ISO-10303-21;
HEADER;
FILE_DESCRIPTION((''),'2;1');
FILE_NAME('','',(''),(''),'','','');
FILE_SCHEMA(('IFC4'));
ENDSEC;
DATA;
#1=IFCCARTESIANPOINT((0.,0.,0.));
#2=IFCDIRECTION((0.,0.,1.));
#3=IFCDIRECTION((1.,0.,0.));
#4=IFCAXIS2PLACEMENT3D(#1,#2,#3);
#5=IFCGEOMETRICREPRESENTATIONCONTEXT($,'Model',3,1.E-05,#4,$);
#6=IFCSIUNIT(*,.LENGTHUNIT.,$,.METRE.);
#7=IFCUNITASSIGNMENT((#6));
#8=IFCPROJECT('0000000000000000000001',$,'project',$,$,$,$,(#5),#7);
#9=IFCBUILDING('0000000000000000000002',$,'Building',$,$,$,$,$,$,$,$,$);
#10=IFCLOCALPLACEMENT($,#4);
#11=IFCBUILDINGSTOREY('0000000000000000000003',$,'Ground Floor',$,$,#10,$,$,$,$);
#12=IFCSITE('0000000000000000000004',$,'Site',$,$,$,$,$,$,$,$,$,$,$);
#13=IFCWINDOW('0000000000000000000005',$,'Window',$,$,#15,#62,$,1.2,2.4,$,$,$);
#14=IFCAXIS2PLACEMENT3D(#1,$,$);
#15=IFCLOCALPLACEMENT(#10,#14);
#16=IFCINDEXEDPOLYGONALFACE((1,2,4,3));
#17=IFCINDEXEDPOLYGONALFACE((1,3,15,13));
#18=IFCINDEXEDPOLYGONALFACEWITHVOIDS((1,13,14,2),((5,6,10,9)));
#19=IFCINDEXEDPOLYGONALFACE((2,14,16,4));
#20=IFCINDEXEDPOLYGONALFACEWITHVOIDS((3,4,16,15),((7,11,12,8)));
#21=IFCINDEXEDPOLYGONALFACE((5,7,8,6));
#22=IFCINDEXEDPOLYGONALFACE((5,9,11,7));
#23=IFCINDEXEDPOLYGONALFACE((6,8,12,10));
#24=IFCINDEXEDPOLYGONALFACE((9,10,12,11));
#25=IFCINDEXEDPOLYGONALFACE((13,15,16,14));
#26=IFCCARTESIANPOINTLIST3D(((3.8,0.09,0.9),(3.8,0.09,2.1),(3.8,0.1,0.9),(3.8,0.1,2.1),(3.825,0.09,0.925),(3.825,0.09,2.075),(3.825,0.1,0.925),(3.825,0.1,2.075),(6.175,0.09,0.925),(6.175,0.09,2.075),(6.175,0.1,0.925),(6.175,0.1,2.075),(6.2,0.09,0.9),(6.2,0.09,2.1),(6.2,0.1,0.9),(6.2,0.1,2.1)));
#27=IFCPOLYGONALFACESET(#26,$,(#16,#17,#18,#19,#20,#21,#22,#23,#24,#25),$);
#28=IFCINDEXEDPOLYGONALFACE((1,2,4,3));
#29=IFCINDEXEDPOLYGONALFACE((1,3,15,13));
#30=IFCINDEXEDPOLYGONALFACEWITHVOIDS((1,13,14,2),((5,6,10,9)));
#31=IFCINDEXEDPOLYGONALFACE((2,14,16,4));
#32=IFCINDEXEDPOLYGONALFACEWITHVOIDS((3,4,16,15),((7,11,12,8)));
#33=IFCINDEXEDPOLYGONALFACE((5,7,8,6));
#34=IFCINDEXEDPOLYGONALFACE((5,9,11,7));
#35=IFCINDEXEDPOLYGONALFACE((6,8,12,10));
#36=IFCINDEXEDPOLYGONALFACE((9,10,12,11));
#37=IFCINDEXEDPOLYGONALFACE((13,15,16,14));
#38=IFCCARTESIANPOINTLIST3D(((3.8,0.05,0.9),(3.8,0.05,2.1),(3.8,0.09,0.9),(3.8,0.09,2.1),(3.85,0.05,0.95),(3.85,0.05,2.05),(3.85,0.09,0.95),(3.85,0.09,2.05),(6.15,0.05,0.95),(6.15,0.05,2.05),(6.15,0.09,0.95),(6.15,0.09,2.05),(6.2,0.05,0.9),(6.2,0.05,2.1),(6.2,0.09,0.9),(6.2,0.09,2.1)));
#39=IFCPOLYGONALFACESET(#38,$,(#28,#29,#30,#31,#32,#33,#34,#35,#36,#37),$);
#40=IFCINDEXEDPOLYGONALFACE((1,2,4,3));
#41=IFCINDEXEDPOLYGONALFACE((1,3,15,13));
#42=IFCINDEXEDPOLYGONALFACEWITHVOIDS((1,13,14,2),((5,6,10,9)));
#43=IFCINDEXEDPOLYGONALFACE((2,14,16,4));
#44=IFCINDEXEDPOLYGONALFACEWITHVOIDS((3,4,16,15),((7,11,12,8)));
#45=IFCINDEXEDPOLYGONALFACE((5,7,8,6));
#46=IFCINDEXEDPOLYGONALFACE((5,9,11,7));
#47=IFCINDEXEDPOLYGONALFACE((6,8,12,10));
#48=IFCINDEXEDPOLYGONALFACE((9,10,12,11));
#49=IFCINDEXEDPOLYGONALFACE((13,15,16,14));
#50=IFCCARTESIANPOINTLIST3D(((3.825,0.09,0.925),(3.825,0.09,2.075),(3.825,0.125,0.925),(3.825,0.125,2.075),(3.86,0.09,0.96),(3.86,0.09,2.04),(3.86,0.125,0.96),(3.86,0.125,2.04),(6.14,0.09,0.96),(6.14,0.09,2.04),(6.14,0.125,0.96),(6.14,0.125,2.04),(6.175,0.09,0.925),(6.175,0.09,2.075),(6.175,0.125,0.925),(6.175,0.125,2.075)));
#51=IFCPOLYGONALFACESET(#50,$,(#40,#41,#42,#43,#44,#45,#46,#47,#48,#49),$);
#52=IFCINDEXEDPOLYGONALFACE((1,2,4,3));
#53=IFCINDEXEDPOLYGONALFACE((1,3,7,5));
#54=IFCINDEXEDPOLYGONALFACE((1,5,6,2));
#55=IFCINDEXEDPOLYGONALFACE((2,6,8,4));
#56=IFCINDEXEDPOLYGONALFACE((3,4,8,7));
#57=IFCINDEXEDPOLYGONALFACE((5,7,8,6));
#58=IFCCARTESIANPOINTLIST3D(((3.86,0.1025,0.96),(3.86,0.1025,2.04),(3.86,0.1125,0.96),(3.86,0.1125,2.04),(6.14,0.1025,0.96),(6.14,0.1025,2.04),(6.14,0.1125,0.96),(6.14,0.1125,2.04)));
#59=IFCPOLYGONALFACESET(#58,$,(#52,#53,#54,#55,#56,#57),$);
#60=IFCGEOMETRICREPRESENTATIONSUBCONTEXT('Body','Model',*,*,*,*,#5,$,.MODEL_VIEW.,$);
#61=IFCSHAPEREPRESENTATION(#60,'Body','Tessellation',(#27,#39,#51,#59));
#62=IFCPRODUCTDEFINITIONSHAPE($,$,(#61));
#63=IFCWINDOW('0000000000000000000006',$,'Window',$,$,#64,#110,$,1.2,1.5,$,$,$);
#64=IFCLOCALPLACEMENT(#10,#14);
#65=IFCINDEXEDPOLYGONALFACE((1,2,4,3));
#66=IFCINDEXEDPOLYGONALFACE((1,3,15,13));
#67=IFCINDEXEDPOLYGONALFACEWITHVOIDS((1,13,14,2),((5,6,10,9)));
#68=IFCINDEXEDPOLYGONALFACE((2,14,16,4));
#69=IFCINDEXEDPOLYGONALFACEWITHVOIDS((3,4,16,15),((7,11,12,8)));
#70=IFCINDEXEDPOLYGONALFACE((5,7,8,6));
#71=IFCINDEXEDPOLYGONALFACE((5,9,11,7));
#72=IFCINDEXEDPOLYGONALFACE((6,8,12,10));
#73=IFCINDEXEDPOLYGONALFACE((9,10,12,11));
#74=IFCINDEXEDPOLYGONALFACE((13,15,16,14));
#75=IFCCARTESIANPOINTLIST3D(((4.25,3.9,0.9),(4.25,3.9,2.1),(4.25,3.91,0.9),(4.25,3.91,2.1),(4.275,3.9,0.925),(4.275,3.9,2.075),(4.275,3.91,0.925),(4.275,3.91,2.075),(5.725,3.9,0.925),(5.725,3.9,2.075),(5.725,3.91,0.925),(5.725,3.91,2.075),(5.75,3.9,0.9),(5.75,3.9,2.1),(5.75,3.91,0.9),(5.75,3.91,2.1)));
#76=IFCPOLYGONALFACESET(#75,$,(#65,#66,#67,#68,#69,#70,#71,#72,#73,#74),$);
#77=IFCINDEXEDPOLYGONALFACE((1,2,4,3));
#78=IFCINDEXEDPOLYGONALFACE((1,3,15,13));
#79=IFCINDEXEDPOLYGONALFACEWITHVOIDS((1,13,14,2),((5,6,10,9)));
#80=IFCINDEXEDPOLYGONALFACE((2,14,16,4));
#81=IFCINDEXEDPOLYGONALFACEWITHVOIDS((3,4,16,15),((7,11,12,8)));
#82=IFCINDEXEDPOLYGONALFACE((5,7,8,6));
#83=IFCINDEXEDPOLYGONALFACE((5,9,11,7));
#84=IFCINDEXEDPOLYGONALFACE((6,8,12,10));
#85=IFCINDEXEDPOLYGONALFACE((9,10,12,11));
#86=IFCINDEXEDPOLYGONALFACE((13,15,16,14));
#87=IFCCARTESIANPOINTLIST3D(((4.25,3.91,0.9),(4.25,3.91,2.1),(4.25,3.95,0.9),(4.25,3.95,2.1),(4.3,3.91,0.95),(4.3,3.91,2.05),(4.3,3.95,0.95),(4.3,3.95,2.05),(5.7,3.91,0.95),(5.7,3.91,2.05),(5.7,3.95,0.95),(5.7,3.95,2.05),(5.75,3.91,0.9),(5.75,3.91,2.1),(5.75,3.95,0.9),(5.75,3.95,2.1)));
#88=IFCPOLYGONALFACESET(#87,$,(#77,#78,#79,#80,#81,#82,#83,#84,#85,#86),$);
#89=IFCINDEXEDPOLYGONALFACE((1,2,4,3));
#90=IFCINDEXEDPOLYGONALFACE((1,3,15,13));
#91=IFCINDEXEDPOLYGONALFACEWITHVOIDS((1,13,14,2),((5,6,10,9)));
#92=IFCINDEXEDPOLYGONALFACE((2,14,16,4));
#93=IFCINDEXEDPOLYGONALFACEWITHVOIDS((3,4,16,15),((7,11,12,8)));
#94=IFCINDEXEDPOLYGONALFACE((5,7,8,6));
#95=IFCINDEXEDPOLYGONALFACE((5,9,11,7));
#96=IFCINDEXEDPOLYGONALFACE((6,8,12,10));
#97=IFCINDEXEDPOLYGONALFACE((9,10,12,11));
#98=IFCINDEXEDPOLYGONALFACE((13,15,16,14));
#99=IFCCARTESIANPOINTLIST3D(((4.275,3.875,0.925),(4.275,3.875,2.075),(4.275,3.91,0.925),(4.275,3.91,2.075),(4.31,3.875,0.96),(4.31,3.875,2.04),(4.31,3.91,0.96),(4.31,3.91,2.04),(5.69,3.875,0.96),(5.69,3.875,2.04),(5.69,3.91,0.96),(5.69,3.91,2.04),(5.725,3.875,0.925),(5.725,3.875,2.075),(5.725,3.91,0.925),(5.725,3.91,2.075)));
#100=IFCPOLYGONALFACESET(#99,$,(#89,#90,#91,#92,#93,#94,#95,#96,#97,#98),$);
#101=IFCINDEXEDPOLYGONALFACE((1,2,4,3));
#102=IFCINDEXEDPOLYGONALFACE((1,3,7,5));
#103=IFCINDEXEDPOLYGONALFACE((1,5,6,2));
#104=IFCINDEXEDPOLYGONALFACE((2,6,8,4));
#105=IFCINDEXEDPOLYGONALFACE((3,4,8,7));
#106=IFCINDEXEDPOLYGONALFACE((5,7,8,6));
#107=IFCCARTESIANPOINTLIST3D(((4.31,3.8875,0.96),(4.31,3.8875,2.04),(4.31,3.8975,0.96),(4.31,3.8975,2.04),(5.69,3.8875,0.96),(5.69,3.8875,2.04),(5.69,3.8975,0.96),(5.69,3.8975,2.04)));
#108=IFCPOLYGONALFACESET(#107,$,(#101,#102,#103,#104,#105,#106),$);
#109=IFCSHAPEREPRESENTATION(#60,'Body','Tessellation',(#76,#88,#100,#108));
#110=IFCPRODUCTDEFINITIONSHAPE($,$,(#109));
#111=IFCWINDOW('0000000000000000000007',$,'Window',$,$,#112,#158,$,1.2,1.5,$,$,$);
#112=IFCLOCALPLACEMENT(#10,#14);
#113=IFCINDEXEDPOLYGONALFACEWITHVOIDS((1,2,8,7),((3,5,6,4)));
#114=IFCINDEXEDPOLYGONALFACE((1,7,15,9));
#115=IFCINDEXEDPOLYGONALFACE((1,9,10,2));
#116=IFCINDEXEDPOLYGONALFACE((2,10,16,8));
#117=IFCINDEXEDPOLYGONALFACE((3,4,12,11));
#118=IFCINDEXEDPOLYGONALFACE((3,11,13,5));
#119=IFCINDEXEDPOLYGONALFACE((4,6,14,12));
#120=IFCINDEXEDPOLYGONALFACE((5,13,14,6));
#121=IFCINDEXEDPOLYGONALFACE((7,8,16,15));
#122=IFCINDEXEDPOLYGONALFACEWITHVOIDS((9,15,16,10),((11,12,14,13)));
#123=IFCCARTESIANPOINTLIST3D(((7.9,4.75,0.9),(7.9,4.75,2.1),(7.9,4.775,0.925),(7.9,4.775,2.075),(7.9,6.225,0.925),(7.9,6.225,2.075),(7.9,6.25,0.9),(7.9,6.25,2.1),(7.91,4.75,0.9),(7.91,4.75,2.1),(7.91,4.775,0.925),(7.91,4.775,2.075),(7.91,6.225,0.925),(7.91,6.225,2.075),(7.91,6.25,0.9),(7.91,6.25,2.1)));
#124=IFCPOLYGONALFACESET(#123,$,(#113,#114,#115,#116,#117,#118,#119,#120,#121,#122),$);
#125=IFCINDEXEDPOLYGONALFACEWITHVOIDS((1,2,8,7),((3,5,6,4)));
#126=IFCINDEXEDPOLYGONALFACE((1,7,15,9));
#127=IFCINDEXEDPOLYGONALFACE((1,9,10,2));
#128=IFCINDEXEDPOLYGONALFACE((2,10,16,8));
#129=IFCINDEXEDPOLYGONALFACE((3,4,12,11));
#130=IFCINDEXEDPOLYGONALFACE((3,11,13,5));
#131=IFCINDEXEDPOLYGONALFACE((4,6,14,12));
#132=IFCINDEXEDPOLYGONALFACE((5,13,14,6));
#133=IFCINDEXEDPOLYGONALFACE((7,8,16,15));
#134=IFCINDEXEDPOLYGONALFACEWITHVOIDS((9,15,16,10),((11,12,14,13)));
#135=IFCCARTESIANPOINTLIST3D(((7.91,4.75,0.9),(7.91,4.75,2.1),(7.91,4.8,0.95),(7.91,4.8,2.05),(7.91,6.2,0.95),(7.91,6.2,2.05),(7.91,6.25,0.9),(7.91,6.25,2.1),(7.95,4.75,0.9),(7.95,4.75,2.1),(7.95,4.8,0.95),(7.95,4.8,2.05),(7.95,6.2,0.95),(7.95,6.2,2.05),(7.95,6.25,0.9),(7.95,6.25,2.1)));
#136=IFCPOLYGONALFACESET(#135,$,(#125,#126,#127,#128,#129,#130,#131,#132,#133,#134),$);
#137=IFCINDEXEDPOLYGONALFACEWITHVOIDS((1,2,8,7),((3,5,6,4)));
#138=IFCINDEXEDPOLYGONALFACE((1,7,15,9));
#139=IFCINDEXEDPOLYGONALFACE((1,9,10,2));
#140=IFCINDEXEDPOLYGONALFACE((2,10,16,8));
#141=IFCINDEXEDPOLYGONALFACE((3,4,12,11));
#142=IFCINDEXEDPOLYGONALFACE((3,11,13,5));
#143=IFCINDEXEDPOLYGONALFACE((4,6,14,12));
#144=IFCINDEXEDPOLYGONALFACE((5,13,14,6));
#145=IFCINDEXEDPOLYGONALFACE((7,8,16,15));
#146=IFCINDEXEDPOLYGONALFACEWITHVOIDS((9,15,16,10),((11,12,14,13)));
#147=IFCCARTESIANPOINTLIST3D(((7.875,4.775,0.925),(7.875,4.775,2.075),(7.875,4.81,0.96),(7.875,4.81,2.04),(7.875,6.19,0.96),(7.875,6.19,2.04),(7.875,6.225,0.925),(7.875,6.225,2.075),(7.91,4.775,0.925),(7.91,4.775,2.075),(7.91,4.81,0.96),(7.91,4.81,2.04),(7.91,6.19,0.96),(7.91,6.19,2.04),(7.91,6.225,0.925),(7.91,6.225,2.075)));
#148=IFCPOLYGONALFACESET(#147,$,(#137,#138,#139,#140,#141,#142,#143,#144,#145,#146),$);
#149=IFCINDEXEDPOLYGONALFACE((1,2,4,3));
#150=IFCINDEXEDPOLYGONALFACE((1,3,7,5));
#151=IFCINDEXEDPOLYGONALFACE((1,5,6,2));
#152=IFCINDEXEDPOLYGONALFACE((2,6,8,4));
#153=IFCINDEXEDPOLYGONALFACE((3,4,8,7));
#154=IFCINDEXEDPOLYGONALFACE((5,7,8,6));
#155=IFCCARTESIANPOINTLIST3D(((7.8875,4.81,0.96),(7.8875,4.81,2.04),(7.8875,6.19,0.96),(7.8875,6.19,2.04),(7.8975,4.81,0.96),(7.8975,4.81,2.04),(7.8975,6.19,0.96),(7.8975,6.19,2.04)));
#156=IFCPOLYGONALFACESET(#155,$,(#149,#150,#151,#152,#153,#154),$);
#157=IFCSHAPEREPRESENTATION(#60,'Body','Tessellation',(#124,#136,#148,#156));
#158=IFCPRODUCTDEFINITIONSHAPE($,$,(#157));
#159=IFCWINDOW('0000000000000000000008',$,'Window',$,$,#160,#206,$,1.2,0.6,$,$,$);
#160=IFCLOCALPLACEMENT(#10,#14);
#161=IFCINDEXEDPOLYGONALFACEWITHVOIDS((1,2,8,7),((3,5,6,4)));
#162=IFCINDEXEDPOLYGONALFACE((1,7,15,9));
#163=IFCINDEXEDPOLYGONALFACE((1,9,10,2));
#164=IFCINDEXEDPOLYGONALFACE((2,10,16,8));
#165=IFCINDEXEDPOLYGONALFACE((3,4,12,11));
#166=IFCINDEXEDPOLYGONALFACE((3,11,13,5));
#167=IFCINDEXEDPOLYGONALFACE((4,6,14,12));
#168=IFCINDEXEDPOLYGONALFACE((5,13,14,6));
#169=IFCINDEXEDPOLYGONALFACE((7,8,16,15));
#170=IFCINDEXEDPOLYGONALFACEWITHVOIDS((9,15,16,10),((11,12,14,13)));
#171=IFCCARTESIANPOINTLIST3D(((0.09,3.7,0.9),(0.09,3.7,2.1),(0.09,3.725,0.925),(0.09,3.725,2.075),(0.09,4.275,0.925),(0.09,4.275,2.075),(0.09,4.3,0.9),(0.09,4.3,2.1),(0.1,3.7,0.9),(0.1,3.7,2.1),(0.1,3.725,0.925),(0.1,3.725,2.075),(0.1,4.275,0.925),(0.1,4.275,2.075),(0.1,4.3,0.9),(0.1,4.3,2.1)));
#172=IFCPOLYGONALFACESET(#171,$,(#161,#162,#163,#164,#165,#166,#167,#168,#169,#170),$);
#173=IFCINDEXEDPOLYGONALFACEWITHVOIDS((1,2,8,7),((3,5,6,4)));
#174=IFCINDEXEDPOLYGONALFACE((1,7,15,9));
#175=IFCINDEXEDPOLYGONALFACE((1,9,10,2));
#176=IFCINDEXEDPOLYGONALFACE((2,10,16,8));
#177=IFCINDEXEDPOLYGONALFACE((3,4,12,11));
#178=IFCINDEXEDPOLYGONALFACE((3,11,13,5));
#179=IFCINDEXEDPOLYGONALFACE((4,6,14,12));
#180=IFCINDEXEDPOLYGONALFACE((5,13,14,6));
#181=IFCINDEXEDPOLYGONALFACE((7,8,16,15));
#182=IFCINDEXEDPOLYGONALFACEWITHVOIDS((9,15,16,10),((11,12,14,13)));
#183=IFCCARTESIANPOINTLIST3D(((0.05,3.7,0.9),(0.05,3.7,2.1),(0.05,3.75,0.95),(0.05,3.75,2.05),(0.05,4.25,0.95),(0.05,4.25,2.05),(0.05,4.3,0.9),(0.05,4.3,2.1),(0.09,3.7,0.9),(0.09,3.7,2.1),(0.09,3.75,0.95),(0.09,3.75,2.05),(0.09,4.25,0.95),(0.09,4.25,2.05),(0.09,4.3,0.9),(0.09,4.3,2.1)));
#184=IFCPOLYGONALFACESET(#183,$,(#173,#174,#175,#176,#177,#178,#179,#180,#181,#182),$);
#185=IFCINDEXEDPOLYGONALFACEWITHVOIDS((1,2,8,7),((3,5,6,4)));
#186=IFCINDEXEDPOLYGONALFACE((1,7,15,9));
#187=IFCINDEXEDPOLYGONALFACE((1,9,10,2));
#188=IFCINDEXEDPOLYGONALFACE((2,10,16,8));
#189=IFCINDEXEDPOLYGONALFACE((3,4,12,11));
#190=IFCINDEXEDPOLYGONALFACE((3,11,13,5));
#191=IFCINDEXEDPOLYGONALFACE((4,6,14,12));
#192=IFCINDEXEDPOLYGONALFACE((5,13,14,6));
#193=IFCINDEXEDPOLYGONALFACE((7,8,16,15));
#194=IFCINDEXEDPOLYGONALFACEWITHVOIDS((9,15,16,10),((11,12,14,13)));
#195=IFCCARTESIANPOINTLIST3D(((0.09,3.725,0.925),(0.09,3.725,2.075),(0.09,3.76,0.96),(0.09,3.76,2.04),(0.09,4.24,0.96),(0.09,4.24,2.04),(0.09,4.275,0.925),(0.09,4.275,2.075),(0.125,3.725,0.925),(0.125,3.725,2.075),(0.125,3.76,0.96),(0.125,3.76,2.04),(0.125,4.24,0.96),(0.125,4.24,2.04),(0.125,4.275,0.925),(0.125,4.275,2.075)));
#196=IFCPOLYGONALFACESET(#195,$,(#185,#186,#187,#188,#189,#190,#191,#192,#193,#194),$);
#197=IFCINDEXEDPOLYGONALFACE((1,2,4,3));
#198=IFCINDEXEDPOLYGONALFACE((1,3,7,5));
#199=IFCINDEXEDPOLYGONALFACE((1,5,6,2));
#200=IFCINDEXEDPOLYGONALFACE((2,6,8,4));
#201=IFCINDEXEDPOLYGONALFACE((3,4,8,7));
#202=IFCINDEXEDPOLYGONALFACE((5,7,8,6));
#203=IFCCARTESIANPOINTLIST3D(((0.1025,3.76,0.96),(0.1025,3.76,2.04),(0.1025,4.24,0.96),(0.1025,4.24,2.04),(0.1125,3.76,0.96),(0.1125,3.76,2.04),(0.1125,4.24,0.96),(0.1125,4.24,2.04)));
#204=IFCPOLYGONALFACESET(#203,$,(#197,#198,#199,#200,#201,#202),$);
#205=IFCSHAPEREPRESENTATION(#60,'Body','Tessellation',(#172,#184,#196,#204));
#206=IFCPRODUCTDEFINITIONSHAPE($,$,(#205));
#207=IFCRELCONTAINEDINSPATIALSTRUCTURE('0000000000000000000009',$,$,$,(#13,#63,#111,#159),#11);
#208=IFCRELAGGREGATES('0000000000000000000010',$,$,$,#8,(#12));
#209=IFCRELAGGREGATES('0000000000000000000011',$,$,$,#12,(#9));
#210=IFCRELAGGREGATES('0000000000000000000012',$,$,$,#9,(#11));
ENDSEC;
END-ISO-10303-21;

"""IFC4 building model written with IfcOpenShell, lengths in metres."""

from ifc_helpers import new_model, si_unit, frame, origin_with_axes, place, context, subcontext, project, spatial, line, indexed_curve, outline, extrude, element, save


model = new_model("IFC4")

# Units and contexts
model_context = context("Model", 3, precision=1e-05, world=origin_with_axes())
body_context = subcontext(model_context, "Body", "Model", "MODEL_VIEW")
ifc_project = project(units=[si_unit("LENGTHUNIT", "METRE")], contexts=[model_context])

# Site, building, storey
site = spatial("IfcSite", under=ifc_project, Name="Site")
building = spatial("IfcBuilding", under=site, Name="Building")
storey_placement = place(None, origin_with_axes())
storey = spatial("IfcBuildingStorey", under=building, at=storey_placement, Name="Ground Floor")

# Windows
window_1_placement = place(storey_placement, frame((3.8, 0.0, 0.9), z_axis=(0.0, 0.0, 1.0), x_axis=(1.0, 0.0, 0.0)))
element("IfcWindow", 1, at=window_1_placement, inside=storey, Name="Window", OverallHeight=1.2, OverallWidth=2.4, context=body_context, shape_type="SweptSolid", body=[
    extrude(outline(indexed_curve([(0.0, 0.0), (2.4, 0.0), (2.4, 1.2), (0.0, 1.2)], segments=[line(1, 2, 3, 4, 1)]), holes=[indexed_curve([(0.025, 0.025), (2.375, 0.025), (2.375, 1.175), (0.025, 1.175)], segments=[line(1, 2, 3, 4, 1)])]), frame((0.0, 0.09, 0.0), z_axis=(0.0, -1.0, 0.0), x_axis=(1.0, 0.0, 0.0)), (0.0, 0.0, -1.0), 0.01),
    extrude(outline(indexed_curve([(0.0, 0.0), (2.4, 0.0), (2.4, 1.2), (0.0, 1.2)], segments=[line(1, 2, 3, 4, 1)]), holes=[indexed_curve([(0.05, 0.05), (2.35, 0.05), (2.35, 1.15), (0.05, 1.15)], segments=[line(1, 2, 3, 4, 1)])]), frame((0.0, 0.05, 0.0), z_axis=(0.0, -1.0, 0.0), x_axis=(1.0, 0.0, 0.0)), (0.0, 0.0, -1.0), 0.04),
    extrude(outline(indexed_curve([(0.0, 0.0), (2.35, 0.0), (2.35, 1.15), (0.0, 1.15)], segments=[line(1, 2, 3, 4, 1)]), holes=[indexed_curve([(0.035, 0.035), (2.315, 0.035), (2.315, 1.115), (0.035, 1.115)], segments=[line(1, 2, 3, 4, 1)])]), frame((0.025, 0.09, 0.025), z_axis=(0.0, -1.0, 0.0), x_axis=(1.0, 0.0, 0.0)), (0.0, 0.0, -1.0), 0.035),
    extrude(outline(indexed_curve([(0.035, 0.035), (2.315, 0.035), (2.315, 1.115), (0.035, 1.115)], segments=[line(1, 2, 3, 4, 1)])), frame((0.025, 0.1025, 0.025), z_axis=(0.0, -1.0, 0.0), x_axis=(1.0, 0.0, 0.0)), (0.0, 0.0, -1.0), 0.01),
])
for number, where, z_axis, x_axis, name in (
    (2, (5.75, 4.0, 0.9), (0.0, 0.0, 1.0), (-1.0, 0.0, 0.0), "Window"),
    (3, (8.0, 4.75, 0.9), (0.0, 0.0, 1.0), (0.0, 1.0, 0.0), "Window"),
):
    element("IfcWindow", number, at=place(storey_placement, frame(where, z_axis=z_axis, x_axis=x_axis)), inside=storey, Name=name, OverallHeight=1.2, OverallWidth=1.5, context=body_context, shape_type="SweptSolid", body=[
        extrude(outline(indexed_curve([(0.0, 0.0), (1.5, 0.0), (1.5, 1.2), (0.0, 1.2)], segments=[line(1, 2, 3, 4, 1)]), holes=[indexed_curve([(0.025, 0.025), (1.475, 0.025), (1.475, 1.175), (0.025, 1.175)], segments=[line(1, 2, 3, 4, 1)])]), frame((0.0, 0.09, 0.0), z_axis=(0.0, -1.0, 0.0), x_axis=(1.0, 0.0, 0.0)), (0.0, 0.0, -1.0), 0.01),
        extrude(outline(indexed_curve([(0.0, 0.0), (1.5, 0.0), (1.5, 1.2), (0.0, 1.2)], segments=[line(1, 2, 3, 4, 1)]), holes=[indexed_curve([(0.05, 0.05), (1.45, 0.05), (1.45, 1.15), (0.05, 1.15)], segments=[line(1, 2, 3, 4, 1)])]), frame((0.0, 0.05, 0.0), z_axis=(0.0, -1.0, 0.0), x_axis=(1.0, 0.0, 0.0)), (0.0, 0.0, -1.0), 0.04),
        extrude(outline(indexed_curve([(0.0, 0.0), (1.45, 0.0), (1.45, 1.15), (0.0, 1.15)], segments=[line(1, 2, 3, 4, 1)]), holes=[indexed_curve([(0.035, 0.035), (1.415, 0.035), (1.415, 1.115), (0.035, 1.115)], segments=[line(1, 2, 3, 4, 1)])]), frame((0.025, 0.09, 0.025), z_axis=(0.0, -1.0, 0.0), x_axis=(1.0, 0.0, 0.0)), (0.0, 0.0, -1.0), 0.035),
        extrude(outline(indexed_curve([(0.035, 0.035), (1.415, 0.035), (1.415, 1.115), (0.035, 1.115)], segments=[line(1, 2, 3, 4, 1)])), frame((0.025, 0.1025, 0.025), z_axis=(0.0, -1.0, 0.0), x_axis=(1.0, 0.0, 0.0)), (0.0, 0.0, -1.0), 0.01),
    ])
window_2_placement = place(storey_placement, frame((0.0, 4.3, 0.9), z_axis=(0.0, 0.0, 1.0), x_axis=(0.0, -1.0, 0.0)))
element("IfcWindow", 4, at=window_2_placement, inside=storey, Name="Window", OverallHeight=1.2, OverallWidth=0.6, context=body_context, shape_type="SweptSolid", body=[
    extrude(outline(indexed_curve([(0.0, 0.0), (0.6, 0.0), (0.6, 1.2), (0.0, 1.2)], segments=[line(1, 2, 3, 4, 1)]), holes=[indexed_curve([(0.025, 0.025), (0.575, 0.025), (0.575, 1.175), (0.025, 1.175)], segments=[line(1, 2, 3, 4, 1)])]), frame((0.0, 0.09, 0.0), z_axis=(0.0, -1.0, 0.0), x_axis=(1.0, 0.0, 0.0)), (0.0, 0.0, -1.0), 0.01),
    extrude(outline(indexed_curve([(0.0, 0.0), (0.6, 0.0), (0.6, 1.2), (0.0, 1.2)], segments=[line(1, 2, 3, 4, 1)]), holes=[indexed_curve([(0.05, 0.05), (0.55, 0.05), (0.55, 1.15), (0.05, 1.15)], segments=[line(1, 2, 3, 4, 1)])]), frame((0.0, 0.05, 0.0), z_axis=(0.0, -1.0, 0.0), x_axis=(1.0, 0.0, 0.0)), (0.0, 0.0, -1.0), 0.04),
    extrude(outline(indexed_curve([(0.0, 0.0), (0.55, 0.0), (0.55, 1.15), (0.0, 1.15)], segments=[line(1, 2, 3, 4, 1)]), holes=[indexed_curve([(0.035, 0.035), (0.515, 0.035), (0.515, 1.115), (0.035, 1.115)], segments=[line(1, 2, 3, 4, 1)])]), frame((0.025, 0.09, 0.025), z_axis=(0.0, -1.0, 0.0), x_axis=(1.0, 0.0, 0.0)), (0.0, 0.0, -1.0), 0.035),
    extrude(outline(indexed_curve([(0.035, 0.035), (0.515, 0.035), (0.515, 1.115), (0.035, 1.115)], segments=[line(1, 2, 3, 4, 1)])), frame((0.025, 0.1025, 0.025), z_axis=(0.0, -1.0, 0.0), x_axis=(1.0, 0.0, 0.0)), (0.0, 0.0, -1.0), 0.01),
])

save(model, "model.ifc")
